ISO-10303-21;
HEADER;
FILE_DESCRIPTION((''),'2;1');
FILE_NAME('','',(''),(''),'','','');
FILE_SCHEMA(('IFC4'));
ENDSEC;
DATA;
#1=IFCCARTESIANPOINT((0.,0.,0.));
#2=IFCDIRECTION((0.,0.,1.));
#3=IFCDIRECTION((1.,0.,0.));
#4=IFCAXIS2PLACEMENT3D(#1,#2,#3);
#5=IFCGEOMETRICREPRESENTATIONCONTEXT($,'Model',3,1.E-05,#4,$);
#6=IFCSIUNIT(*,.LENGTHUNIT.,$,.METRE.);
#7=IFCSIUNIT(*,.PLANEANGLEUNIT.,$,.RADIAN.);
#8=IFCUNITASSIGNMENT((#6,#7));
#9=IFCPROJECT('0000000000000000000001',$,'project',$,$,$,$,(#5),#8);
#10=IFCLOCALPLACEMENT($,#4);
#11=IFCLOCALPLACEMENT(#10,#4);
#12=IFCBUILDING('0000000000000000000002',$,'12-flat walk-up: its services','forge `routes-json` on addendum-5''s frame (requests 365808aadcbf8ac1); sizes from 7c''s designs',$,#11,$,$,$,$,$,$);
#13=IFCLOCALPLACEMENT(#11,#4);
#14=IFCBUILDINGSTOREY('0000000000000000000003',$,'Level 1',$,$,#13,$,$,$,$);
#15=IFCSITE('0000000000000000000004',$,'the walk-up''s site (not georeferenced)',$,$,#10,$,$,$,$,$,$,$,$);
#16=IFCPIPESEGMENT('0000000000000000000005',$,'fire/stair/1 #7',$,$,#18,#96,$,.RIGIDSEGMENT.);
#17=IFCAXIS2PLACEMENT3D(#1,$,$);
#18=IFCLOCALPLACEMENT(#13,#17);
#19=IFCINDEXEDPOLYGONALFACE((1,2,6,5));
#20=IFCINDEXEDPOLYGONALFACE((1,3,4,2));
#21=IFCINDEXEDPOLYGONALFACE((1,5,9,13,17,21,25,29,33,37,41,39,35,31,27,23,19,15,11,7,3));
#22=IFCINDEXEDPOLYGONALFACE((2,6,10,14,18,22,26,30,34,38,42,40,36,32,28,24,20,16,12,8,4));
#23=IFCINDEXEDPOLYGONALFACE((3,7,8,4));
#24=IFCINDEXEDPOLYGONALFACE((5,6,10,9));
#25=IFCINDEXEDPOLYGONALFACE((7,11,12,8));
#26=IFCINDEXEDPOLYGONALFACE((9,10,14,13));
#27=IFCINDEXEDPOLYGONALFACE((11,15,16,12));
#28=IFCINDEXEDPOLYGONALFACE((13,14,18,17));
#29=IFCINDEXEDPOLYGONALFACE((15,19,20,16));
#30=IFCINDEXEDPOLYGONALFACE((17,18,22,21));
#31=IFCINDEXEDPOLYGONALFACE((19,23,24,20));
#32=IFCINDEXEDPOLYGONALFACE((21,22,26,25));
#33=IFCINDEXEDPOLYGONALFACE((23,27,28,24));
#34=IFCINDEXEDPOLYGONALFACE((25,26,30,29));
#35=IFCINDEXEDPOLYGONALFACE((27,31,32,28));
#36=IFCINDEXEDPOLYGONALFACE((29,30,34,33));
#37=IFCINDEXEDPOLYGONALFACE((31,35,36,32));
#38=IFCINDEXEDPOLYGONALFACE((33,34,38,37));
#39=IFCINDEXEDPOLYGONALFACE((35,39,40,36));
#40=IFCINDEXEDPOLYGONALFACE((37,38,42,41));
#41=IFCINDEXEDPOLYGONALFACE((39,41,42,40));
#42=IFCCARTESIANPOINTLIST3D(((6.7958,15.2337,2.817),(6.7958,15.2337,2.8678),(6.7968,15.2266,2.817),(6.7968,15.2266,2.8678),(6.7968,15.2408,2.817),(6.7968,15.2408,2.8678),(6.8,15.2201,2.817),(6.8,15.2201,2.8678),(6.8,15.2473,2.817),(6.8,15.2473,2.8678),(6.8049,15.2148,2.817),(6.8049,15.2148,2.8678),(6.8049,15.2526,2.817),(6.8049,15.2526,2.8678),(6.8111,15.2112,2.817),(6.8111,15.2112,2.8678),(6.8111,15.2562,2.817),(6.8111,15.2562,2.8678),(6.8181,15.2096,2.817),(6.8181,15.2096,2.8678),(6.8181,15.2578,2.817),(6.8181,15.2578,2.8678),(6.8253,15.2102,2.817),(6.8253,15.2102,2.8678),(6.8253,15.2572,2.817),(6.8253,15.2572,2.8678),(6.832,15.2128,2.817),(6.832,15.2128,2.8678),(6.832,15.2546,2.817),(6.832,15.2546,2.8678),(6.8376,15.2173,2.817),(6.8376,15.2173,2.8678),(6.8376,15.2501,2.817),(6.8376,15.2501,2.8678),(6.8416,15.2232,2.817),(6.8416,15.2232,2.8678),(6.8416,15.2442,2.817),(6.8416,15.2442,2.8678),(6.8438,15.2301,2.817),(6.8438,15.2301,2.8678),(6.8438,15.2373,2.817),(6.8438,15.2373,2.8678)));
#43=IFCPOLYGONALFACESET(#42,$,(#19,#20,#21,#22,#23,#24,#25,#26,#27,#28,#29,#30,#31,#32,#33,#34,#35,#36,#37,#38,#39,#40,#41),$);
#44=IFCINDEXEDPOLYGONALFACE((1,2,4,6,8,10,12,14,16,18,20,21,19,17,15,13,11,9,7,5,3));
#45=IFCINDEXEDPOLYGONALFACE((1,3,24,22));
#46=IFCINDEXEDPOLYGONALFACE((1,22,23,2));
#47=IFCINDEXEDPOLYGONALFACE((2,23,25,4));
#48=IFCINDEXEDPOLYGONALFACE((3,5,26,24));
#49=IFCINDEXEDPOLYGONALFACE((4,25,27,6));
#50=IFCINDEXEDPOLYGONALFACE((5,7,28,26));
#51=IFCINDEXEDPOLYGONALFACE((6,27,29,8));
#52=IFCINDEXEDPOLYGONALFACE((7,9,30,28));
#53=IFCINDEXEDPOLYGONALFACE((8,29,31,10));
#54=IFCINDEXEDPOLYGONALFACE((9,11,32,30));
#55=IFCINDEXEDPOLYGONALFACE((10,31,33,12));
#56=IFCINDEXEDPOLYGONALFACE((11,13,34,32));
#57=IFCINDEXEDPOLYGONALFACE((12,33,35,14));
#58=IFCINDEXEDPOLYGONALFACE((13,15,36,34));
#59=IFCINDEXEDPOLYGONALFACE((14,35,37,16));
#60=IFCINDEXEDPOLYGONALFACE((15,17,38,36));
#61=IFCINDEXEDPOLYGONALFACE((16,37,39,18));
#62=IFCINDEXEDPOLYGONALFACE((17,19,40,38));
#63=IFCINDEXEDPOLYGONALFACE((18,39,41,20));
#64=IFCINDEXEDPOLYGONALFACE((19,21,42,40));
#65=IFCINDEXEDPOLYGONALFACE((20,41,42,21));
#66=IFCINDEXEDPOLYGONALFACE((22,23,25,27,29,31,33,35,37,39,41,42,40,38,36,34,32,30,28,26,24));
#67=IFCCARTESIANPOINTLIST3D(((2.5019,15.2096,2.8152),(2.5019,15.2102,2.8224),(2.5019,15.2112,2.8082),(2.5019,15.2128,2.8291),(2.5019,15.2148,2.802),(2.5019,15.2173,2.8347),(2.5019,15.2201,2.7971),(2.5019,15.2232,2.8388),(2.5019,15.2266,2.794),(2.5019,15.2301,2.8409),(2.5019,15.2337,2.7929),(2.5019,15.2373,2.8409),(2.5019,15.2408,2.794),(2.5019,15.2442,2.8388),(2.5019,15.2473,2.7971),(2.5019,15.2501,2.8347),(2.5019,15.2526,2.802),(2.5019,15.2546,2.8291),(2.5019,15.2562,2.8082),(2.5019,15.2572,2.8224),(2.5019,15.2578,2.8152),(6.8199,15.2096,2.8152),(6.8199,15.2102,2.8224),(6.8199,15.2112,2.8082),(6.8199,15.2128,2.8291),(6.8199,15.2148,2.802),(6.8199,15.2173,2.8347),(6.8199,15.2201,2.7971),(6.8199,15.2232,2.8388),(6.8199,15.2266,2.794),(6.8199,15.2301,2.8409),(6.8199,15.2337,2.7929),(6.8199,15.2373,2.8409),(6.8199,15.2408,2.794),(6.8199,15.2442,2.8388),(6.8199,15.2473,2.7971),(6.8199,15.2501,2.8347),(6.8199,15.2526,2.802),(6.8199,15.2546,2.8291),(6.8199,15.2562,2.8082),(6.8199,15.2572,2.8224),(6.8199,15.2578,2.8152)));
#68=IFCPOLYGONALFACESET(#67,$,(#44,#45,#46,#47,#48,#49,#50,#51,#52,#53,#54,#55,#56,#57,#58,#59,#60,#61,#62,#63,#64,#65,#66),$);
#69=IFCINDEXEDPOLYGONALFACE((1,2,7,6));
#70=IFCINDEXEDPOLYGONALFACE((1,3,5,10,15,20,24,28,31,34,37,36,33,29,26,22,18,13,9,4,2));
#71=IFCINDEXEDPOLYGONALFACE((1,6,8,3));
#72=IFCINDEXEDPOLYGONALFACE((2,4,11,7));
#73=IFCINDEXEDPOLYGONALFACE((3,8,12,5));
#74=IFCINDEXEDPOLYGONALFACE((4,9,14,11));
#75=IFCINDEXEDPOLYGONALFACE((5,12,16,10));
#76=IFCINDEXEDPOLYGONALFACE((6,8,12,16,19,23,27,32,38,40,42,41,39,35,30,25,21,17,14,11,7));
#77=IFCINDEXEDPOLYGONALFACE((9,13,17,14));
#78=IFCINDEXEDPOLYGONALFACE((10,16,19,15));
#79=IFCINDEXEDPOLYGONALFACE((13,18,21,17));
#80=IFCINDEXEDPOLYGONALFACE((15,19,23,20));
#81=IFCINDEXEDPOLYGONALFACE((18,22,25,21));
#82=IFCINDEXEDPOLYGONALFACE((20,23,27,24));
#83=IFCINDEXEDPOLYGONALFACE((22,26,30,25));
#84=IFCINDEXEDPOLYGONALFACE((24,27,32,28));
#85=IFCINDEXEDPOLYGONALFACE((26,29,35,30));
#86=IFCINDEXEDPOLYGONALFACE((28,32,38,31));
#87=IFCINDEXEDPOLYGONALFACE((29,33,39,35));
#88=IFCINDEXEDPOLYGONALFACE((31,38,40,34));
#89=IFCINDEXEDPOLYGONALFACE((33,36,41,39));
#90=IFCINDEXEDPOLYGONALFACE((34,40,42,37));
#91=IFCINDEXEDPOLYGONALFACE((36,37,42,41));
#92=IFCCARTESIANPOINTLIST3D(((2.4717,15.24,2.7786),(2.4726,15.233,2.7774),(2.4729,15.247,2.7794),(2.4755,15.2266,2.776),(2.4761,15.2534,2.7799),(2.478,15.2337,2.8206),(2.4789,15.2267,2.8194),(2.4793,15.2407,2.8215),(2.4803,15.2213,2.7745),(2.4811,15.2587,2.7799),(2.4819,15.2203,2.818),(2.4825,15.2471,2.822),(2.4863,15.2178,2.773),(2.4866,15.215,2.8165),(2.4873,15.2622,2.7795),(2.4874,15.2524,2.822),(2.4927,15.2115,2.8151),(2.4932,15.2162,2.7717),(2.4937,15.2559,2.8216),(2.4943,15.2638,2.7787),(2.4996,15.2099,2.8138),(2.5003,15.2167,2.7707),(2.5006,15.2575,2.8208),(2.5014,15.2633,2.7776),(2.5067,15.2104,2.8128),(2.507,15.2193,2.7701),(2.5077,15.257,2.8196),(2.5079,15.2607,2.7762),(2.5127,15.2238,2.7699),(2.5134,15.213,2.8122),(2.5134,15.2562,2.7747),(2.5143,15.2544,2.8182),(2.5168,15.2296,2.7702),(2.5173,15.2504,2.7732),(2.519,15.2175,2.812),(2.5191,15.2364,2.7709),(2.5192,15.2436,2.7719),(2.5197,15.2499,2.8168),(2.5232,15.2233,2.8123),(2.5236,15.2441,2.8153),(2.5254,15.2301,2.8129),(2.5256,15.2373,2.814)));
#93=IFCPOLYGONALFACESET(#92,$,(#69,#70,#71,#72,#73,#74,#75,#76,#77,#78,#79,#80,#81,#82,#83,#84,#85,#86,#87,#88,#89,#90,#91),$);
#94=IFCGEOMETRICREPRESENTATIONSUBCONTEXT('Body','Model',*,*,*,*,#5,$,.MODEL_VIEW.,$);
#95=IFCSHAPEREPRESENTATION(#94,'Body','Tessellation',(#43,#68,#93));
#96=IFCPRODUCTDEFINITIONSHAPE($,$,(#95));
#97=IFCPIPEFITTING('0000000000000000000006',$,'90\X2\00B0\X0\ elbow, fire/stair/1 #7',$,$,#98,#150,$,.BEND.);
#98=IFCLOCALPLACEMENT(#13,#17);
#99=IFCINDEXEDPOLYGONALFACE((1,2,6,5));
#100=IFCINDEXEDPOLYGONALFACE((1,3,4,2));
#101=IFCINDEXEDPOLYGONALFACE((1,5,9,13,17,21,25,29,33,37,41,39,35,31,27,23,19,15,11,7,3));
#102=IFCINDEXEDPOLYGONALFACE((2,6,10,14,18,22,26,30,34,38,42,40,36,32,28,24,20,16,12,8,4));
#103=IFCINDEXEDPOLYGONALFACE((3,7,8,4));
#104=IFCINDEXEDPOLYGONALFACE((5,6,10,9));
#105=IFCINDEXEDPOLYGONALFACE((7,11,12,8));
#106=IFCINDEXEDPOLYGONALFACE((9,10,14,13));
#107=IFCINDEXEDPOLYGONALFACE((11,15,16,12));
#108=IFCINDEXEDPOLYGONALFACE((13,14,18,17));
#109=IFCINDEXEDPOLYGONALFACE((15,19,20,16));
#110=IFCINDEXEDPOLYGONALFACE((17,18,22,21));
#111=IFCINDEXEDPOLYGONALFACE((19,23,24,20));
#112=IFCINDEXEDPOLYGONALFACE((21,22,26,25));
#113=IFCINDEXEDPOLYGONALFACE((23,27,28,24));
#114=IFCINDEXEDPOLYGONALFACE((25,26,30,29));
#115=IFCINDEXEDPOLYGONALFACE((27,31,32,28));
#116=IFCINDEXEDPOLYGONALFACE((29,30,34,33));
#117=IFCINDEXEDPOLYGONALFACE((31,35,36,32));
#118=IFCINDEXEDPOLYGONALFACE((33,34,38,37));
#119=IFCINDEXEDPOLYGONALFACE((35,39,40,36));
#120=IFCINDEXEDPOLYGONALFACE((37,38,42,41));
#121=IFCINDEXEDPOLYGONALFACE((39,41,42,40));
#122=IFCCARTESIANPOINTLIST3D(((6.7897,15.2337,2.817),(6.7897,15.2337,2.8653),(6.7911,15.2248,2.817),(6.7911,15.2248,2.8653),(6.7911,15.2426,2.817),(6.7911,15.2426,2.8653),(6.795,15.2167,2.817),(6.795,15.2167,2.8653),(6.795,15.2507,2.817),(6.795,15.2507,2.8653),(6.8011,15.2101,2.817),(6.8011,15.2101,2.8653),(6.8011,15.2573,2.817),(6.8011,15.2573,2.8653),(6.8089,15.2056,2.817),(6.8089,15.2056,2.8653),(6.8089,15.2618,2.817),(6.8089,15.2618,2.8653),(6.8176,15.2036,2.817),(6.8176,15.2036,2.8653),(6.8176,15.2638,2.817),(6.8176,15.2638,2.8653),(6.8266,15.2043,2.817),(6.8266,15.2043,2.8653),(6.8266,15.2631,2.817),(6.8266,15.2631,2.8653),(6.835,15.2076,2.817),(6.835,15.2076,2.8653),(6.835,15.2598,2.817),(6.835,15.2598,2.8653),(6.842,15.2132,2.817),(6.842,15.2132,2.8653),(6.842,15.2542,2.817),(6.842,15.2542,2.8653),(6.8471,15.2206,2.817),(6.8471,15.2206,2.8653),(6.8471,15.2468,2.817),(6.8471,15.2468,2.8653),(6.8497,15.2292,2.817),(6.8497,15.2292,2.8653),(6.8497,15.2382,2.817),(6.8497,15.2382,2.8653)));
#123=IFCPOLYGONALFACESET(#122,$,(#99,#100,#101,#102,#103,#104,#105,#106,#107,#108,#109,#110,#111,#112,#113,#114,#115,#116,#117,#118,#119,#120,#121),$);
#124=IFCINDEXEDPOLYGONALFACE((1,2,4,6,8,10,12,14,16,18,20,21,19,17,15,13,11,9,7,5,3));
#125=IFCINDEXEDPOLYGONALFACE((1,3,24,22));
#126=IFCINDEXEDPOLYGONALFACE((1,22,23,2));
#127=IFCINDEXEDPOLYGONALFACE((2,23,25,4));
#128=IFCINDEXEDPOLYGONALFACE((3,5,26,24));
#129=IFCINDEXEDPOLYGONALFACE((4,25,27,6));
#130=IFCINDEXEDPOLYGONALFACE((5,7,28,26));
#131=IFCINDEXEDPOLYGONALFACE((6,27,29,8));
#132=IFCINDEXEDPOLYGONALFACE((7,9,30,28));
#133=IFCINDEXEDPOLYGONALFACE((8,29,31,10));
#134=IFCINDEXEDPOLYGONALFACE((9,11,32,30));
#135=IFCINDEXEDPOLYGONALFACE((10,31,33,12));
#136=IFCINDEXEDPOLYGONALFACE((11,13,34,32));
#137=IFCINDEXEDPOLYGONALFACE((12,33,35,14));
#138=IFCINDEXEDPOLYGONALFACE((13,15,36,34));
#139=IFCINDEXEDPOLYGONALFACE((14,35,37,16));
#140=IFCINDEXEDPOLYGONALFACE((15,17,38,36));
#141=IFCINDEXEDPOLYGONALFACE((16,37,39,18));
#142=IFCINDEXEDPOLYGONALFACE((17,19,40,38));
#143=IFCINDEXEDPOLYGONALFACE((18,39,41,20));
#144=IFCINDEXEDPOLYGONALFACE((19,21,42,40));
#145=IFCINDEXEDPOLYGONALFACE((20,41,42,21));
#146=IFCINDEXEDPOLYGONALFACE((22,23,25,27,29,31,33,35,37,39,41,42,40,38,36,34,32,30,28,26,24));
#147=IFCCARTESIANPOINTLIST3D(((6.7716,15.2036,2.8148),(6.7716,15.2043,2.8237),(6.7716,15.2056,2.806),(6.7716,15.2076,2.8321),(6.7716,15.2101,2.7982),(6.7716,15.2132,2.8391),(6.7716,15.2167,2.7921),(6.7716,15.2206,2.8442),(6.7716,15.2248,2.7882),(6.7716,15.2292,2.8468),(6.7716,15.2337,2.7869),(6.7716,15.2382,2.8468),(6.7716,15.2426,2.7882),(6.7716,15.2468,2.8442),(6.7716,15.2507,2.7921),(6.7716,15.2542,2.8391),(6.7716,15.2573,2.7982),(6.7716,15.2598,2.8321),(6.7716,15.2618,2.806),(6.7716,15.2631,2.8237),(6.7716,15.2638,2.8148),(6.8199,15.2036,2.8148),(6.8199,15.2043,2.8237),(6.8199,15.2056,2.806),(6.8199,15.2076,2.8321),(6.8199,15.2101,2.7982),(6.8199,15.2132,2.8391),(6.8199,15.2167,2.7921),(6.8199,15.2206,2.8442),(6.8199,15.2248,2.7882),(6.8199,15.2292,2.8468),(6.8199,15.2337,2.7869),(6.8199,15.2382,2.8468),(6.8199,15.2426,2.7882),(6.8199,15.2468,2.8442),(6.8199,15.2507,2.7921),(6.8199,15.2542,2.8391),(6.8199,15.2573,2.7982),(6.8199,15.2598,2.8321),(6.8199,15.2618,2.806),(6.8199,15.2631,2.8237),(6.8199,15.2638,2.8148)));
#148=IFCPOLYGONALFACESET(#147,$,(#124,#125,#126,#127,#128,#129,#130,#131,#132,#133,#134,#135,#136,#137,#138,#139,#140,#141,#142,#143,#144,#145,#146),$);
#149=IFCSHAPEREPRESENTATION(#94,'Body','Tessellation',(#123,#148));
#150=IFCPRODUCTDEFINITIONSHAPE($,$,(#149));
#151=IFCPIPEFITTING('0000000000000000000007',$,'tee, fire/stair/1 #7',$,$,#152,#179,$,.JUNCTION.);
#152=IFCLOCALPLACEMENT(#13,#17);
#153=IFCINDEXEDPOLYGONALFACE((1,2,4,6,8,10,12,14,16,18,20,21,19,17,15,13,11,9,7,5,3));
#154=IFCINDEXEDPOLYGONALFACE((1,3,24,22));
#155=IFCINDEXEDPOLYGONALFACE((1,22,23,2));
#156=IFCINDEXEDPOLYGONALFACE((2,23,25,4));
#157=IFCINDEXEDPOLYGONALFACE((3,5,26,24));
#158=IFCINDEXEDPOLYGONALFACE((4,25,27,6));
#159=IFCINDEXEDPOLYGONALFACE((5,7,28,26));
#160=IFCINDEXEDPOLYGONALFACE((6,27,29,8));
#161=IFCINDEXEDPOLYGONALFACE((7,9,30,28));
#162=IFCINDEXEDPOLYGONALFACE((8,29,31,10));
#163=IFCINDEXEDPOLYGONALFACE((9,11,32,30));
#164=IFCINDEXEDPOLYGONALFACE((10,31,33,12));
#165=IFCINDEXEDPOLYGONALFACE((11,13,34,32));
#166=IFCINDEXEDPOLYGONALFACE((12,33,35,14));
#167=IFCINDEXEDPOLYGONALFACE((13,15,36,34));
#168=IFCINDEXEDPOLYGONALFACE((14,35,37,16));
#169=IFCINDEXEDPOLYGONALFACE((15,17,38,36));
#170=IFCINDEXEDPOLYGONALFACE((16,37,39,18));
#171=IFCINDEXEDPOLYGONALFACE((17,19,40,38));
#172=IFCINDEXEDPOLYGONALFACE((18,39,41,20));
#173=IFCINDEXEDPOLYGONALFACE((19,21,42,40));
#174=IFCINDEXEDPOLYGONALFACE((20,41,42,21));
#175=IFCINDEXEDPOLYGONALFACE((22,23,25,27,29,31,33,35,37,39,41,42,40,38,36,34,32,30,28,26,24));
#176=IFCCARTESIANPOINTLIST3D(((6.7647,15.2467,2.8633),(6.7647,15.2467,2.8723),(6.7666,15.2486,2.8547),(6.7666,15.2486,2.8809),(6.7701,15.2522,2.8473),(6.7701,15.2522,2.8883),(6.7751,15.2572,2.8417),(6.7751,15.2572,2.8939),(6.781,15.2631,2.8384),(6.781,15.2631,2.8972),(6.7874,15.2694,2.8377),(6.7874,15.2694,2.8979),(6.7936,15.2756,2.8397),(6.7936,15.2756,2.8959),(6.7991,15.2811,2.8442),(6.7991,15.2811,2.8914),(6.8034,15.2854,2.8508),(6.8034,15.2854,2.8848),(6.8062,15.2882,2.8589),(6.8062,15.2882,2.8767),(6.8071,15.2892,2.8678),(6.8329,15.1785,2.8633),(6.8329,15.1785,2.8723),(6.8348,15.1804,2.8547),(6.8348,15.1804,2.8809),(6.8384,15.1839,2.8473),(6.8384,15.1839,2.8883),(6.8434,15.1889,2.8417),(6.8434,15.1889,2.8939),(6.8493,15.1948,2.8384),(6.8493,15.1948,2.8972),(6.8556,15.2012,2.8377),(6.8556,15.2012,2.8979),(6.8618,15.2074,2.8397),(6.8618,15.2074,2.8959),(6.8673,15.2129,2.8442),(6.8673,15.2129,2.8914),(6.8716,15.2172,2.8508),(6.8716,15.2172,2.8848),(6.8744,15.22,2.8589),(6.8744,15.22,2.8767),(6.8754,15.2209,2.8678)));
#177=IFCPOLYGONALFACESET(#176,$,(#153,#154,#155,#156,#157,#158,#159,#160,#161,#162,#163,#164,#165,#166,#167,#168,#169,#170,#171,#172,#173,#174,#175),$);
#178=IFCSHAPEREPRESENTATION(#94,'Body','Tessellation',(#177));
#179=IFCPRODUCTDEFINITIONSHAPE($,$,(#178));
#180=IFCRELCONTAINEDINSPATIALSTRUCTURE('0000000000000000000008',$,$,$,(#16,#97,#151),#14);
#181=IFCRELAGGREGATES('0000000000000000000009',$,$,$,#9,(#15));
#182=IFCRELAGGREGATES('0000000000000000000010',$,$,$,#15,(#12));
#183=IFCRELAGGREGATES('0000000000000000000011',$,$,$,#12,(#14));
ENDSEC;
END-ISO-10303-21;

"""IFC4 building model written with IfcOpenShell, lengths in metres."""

from ifc_helpers import new_model, entity, si_unit, frame, origin_with_axes, place, context, subcontext, project, spatial, element, save


model = new_model("IFC4")

# Units and contexts
model_context = context("Model", 3, precision=1e-05, world=origin_with_axes())
body_context = subcontext(model_context, "Body", "Model", "MODEL_VIEW")
ifc_project = project(units=[si_unit("LENGTHUNIT", "METRE"), si_unit("PLANEANGLEUNIT", "RADIAN")], contexts=[model_context])

# Site, building, storey
site_placement = place(None, origin_with_axes())
site = spatial("IfcSite", under=ifc_project, at=site_placement, Name="the walk-up's site (not georeferenced)")
building_placement = place(site_placement, origin_with_axes())
building = spatial("IfcBuilding", under=site, at=building_placement, Name="12-flat walk-up: its services", Description="forge `routes-json` on addendum-5's frame (requests 365808aadcbf8ac1); sizes from 7c's designs")
storey_placement = place(building_placement, origin_with_axes())
storey = spatial("IfcBuildingStorey", under=building, at=storey_placement, Name="Level 1")

# Pipe segment
pipe_segment_1_placement = place(storey_placement, frame((6.8199, 15.2337, 2.8678), z_axis=(0.0, 0.0, 1.0), x_axis=(1.0, 0.0, 0.0)))
element("IfcPipeSegment", 1, at=pipe_segment_1_placement, inside=storey, Name="fire/stair/1 #7", PredefinedType="RIGIDSEGMENT", context=body_context, shape_type="AdvancedSweptSolid", body=[
    entity("IfcSweptDiskSolid", entity("IfcPolyline", [entity("IfcCartesianPoint", [0.0, 0.0, 0.0]), entity("IfcCartesianPoint", [0.0, 0.0, -0.0508])]), 0.0241),
    entity("IfcSweptDiskSolid", entity("IfcPolyline", [entity("IfcCartesianPoint", [0.0, 0.0, -0.0508]), entity("IfcCartesianPoint", [-4.318, 0.0, -0.0508])]), 0.0241),
    entity("IfcSweptDiskSolid", entity("IfcPolyline", [entity("IfcCartesianPoint", [-4.318, 0.0, -0.0508]), entity("IfcCartesianPoint", [-4.3243, 0.0063, -0.0929])]), 0.0241),
])

# Pipe fittings
pipe_fitting_1_placement = place(storey_placement, frame((6.8199, 15.2337, 2.8653), z_axis=(0.0, 0.0, 1.0), x_axis=(1.0, 0.0, 0.0)))
element("IfcPipeFitting", 2, at=pipe_fitting_1_placement, inside=storey, Name="90° elbow, fire/stair/1 #7", PredefinedType="BEND", context=body_context, shape_type="AdvancedSweptSolid", body=[
    entity("IfcSweptDiskSolid", entity("IfcPolyline", [entity("IfcCartesianPoint", [0.0, 0.0, 0.0]), entity("IfcCartesianPoint", [0.0, 0.0, -0.0483])]), 0.0302),
    entity("IfcSweptDiskSolid", entity("IfcPolyline", [entity("IfcCartesianPoint", [0.0, 0.0, -0.0483]), entity("IfcCartesianPoint", [-0.0483, 0.0, -0.0483])]), 0.0302),
])
pipe_fitting_2_placement = place(storey_placement, frame((6.854, 15.1996, 2.8678), z_axis=(0.0, 0.0, 1.0), x_axis=(1.0, 0.0, 0.0)))
element("IfcPipeFitting", 3, at=pipe_fitting_2_placement, inside=storey, Name="tee, fire/stair/1 #7", PredefinedType="JUNCTION", context=body_context, shape_type="AdvancedSweptSolid", body=[
    entity("IfcSweptDiskSolid", entity("IfcPolyline", [entity("IfcCartesianPoint", [0.0, 0.0, 0.0]), entity("IfcCartesianPoint", [-0.0682, 0.0682, 0.0])]), 0.0302),
])

save(model, "model.ifc")
